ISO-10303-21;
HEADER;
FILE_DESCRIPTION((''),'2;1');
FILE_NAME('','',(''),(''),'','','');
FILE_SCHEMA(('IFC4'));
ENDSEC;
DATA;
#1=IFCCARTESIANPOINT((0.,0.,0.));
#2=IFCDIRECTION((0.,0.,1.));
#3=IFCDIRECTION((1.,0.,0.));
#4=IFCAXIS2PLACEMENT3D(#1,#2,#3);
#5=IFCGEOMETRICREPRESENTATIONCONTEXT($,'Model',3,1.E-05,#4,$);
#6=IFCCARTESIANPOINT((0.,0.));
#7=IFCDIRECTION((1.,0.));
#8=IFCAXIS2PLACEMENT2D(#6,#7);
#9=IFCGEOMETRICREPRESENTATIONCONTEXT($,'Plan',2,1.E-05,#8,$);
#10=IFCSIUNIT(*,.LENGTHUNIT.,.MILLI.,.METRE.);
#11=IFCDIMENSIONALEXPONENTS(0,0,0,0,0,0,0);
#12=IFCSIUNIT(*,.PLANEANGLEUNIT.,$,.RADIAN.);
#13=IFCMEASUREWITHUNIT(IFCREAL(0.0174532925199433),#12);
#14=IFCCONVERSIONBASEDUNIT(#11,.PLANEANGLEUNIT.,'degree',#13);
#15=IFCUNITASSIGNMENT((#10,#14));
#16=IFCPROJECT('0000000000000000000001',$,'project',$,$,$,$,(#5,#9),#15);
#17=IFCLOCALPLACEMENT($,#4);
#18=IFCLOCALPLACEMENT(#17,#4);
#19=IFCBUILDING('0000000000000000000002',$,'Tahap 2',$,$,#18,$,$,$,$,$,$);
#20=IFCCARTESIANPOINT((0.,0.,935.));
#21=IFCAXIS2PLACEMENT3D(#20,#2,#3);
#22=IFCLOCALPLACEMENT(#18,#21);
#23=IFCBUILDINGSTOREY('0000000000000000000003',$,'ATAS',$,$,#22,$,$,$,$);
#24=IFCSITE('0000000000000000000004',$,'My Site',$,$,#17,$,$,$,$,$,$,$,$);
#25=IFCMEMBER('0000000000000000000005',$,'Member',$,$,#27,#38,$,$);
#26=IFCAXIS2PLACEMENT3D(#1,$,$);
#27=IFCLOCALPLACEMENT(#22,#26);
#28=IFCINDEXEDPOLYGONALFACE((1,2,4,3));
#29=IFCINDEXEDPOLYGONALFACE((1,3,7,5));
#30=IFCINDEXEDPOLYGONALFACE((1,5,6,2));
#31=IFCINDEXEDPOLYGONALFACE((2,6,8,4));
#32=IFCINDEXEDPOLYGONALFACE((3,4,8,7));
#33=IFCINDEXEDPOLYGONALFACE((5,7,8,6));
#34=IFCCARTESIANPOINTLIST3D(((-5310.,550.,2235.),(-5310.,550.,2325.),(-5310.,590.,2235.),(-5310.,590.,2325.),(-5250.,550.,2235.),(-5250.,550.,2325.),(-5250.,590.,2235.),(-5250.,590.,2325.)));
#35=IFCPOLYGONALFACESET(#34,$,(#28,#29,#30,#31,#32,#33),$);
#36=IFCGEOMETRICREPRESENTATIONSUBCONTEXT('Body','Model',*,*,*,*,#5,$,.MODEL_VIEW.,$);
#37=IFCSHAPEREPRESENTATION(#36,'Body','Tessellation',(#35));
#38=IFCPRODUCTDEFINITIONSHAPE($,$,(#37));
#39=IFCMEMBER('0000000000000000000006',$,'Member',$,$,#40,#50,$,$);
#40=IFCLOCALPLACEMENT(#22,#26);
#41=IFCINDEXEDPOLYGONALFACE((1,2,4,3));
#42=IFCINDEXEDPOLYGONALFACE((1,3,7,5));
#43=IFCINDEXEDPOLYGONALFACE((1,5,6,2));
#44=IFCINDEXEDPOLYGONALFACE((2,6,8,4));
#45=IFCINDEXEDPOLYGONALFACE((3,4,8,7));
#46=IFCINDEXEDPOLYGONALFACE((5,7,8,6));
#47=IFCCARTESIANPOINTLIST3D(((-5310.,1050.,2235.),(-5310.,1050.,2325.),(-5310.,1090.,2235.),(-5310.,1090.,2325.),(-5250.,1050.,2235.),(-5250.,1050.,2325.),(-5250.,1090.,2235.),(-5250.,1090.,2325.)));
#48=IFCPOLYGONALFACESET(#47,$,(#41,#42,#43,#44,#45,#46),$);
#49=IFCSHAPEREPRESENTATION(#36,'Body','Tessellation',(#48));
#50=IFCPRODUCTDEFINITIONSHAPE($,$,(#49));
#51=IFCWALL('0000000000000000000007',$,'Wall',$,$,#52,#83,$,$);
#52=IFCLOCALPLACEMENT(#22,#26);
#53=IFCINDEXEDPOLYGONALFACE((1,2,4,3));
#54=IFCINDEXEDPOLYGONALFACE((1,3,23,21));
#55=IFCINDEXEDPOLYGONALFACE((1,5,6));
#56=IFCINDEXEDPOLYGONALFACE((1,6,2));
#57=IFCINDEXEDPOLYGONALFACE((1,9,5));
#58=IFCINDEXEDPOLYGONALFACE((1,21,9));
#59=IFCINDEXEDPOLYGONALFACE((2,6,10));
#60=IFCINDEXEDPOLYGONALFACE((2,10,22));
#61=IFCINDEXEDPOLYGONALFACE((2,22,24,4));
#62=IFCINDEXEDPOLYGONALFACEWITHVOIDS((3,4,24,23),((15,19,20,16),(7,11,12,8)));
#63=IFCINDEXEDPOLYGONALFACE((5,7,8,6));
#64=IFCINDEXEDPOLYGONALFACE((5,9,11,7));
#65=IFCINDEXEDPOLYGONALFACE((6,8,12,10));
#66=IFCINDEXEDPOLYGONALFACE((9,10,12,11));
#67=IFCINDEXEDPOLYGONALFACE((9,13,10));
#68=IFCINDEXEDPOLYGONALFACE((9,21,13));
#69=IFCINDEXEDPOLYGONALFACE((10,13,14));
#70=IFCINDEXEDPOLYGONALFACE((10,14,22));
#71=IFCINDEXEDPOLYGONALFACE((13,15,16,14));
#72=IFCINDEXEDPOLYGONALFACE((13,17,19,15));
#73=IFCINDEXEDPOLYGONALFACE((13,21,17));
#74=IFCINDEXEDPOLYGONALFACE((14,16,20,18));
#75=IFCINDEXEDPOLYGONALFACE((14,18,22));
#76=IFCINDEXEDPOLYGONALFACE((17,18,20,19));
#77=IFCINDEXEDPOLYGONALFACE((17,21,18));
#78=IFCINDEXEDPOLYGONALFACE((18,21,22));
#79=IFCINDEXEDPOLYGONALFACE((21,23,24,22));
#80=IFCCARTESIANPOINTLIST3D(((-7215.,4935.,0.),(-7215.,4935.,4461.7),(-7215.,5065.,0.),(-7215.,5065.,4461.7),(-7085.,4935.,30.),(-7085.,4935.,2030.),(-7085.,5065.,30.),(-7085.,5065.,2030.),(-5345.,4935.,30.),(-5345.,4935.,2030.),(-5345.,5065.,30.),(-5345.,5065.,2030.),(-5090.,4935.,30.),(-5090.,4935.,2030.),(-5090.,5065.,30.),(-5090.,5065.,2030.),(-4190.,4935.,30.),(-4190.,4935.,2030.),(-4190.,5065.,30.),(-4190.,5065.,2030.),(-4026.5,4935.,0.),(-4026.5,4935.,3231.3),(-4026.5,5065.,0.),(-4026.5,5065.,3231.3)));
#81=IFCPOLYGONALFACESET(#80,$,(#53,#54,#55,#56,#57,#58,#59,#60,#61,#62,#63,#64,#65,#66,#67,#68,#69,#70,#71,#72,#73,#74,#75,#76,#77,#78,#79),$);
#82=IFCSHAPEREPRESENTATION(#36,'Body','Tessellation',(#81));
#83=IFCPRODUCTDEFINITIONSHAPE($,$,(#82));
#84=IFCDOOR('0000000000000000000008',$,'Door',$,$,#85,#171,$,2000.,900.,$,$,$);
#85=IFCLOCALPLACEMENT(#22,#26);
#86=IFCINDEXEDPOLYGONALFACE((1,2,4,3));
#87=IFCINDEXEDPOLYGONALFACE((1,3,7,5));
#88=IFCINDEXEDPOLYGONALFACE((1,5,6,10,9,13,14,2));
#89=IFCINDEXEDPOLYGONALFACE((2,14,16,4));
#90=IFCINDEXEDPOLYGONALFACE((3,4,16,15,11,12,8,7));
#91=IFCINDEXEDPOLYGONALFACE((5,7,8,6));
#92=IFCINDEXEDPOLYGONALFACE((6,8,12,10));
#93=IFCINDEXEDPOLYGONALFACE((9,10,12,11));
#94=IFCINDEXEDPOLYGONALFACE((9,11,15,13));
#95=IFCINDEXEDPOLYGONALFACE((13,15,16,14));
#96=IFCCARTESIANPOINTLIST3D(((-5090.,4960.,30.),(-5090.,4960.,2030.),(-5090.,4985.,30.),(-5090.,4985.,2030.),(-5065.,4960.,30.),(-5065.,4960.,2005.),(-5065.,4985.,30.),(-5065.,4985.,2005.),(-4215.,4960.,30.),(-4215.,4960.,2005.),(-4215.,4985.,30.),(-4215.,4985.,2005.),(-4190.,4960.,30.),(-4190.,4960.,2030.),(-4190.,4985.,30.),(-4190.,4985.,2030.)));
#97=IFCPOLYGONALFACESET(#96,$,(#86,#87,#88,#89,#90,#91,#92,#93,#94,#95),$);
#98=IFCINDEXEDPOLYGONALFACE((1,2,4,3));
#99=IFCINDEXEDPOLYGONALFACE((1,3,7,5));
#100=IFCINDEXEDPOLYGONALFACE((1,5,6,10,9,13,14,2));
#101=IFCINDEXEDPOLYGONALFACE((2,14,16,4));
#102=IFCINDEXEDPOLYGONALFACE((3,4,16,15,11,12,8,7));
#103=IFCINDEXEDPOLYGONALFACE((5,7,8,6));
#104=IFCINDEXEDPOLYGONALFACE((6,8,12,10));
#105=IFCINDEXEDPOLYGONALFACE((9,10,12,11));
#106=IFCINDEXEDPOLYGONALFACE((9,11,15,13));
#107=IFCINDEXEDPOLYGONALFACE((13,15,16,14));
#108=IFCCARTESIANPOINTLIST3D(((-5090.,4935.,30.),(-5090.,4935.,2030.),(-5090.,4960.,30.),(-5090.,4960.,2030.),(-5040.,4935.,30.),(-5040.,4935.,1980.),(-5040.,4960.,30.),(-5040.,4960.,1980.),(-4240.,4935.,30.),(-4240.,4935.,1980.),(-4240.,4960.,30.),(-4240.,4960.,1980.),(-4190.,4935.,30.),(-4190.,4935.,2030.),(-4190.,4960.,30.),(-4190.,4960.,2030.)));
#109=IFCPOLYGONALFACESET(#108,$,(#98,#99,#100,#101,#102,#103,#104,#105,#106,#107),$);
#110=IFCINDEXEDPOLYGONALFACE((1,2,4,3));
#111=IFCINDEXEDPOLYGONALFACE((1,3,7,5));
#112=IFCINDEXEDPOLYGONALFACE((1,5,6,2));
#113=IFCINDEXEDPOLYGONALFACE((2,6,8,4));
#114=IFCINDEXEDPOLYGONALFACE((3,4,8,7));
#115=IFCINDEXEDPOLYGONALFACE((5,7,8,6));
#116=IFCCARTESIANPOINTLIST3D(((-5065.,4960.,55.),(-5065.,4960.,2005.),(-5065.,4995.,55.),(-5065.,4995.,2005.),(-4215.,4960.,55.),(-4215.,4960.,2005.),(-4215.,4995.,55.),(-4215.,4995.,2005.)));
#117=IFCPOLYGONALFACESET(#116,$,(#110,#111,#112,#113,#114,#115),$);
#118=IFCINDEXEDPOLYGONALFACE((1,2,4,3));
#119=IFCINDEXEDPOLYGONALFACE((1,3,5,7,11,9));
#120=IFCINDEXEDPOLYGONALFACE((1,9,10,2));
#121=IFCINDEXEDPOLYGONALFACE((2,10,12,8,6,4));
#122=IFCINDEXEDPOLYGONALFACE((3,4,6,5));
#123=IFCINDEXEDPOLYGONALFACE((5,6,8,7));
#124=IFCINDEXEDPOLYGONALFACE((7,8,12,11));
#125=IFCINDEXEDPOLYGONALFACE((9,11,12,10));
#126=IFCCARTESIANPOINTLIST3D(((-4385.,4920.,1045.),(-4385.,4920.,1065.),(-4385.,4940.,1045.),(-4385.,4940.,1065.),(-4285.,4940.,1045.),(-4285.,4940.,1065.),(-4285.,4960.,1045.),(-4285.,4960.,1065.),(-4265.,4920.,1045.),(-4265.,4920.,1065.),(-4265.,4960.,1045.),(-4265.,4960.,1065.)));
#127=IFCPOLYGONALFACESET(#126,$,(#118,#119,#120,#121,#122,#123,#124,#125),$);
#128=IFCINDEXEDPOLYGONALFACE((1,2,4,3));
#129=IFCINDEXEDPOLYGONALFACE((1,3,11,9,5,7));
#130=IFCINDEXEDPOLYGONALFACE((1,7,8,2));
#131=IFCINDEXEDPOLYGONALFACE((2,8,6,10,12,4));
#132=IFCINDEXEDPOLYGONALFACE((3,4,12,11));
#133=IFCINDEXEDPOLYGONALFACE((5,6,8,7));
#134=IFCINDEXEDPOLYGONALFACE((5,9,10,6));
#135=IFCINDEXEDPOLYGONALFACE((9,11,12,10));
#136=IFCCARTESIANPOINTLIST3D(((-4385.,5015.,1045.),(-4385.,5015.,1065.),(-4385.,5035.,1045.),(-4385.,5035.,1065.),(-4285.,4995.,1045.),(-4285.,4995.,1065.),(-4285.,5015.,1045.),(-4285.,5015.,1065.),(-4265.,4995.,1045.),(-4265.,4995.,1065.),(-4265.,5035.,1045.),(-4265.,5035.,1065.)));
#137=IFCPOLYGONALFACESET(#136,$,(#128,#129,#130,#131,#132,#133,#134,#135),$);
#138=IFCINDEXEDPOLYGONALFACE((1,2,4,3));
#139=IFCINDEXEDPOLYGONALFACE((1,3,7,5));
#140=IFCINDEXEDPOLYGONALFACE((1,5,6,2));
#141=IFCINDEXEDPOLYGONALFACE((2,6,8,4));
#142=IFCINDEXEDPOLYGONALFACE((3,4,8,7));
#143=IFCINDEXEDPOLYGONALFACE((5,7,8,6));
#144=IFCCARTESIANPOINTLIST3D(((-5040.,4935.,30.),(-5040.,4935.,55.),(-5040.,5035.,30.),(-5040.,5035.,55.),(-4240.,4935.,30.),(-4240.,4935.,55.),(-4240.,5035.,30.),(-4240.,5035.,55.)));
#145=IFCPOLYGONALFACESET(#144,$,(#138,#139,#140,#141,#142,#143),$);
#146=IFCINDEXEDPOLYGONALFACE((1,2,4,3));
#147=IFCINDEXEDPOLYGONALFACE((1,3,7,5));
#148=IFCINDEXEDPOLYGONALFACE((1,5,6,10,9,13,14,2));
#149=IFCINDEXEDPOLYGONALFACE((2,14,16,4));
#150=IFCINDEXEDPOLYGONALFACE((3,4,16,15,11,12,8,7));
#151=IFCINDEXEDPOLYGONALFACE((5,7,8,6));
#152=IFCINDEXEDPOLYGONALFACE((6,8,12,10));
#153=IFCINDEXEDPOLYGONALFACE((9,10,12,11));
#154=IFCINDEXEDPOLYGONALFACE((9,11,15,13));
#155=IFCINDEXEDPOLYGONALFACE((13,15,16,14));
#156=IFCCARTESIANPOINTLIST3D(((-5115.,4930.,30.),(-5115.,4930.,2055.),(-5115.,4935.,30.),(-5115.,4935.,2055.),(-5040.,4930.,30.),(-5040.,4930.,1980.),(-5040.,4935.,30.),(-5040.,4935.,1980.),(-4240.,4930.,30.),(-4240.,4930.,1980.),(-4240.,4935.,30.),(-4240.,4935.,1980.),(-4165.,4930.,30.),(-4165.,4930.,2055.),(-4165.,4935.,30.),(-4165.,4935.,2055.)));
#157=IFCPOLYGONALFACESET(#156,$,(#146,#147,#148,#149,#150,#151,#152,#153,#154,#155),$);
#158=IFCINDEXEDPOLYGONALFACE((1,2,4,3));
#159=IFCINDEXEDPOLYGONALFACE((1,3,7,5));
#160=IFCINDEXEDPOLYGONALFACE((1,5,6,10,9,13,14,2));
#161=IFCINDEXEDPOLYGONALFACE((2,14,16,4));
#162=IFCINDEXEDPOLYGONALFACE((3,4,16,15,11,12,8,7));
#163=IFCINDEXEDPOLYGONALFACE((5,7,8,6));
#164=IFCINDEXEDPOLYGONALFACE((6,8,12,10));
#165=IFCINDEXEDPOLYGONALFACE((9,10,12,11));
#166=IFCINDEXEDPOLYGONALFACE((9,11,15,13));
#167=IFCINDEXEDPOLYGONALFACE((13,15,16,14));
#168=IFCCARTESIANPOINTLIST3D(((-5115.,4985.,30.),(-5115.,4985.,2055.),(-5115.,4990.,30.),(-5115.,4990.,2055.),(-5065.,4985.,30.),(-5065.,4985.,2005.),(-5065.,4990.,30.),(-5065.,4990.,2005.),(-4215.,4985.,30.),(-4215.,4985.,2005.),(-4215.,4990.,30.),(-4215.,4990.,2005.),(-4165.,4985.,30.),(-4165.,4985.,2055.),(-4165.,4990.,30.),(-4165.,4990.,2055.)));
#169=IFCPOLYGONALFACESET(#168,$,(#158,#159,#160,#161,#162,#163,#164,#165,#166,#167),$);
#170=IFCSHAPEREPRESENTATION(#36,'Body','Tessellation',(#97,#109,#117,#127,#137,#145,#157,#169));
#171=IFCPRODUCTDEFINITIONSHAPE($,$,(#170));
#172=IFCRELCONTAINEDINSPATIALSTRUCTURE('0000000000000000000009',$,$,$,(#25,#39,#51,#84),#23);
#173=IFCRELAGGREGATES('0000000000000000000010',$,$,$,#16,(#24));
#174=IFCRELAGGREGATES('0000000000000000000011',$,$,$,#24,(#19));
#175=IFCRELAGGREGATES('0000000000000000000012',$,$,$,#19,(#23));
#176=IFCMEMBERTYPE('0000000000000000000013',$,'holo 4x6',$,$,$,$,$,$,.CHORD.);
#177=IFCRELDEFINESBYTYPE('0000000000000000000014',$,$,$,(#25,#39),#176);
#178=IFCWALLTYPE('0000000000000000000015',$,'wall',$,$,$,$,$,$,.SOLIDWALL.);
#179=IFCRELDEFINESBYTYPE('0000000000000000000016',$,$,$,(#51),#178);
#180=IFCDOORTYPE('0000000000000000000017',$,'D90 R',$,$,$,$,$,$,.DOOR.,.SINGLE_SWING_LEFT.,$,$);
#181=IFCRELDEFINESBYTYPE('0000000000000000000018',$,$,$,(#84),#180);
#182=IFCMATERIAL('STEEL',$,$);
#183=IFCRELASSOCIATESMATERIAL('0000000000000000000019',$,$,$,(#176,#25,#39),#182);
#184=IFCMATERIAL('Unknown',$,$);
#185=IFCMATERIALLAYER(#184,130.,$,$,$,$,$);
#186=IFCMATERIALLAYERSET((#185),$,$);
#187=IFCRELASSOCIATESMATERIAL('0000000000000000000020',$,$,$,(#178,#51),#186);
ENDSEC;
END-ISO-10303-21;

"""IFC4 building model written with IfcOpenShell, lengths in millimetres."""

from ifc_helpers import new_model, entity, si_unit, converted_unit, frame, origin_with_axes, origin_2d_with_axis, place, context, subcontext, project, spatial, line, indexed_curve, rectangle, outline, extrude, clip, halfspace, shape, source, transform, mapped, material, layer, layer_set, layer_usage, material_profile, profile_set, profile_usage, type_object, type_shapes, element, fill, save


model = new_model("IFC4")

# Units and contexts
model_context = context("Model", 3, precision=1e-05, world=origin_with_axes())
plan_context = context("Plan", 2, precision=1e-05, world=origin_2d_with_axis())
body_context_1 = subcontext(model_context, "Body", "Model", "MODEL_VIEW")
body_context_2 = subcontext(plan_context, "Body", "Plan", "PLAN_VIEW")
ifc_project = project(units=[si_unit("LENGTHUNIT", "METRE", prefix="MILLI"), converted_unit("PLANEANGLEUNIT", "degree", entity("IfcReal", 0.0174532925199433), si_unit("PLANEANGLEUNIT", "RADIAN"), dimensions=[0, 0, 0, 0, 0, 0, 0])], contexts=[model_context, plan_context])

# Site, building, storey
site_placement = place(None, origin_with_axes())
site = spatial("IfcSite", under=ifc_project, at=site_placement, Name="My Site")
building_placement = place(site_placement, origin_with_axes())
building = spatial("IfcBuilding", under=site, at=building_placement, Name="Tahap 2")
storey_placement = place(building_placement, frame((0.0, 0.0, 935.0), z_axis=(0.0, 0.0, 1.0), x_axis=(1.0, 0.0, 0.0)))
storey = spatial("IfcBuildingStorey", under=building, at=storey_placement, Name="ATAS")

# Members
ifc_material_1 = material(Name="STEEL")
ifc_material_profile = material_profile(ifc_material_1, rectangle(XDim=40.0, YDim=60.0, kind="CURVE"))
ifc_profile_set = profile_set([ifc_material_profile])
ifc_profile_usage_1 = profile_usage(ifc_profile_set, cardinal=8)
member_type = type_object("IfcMemberType", Name="holo 4x6", PredefinedType="CHORD", material=ifc_profile_set)
member_1_placement = place(storey_placement, frame((-5250.0, 570.0, 2235.0), z_axis=(0.0, 0.0, 1.0), x_axis=(0.0, -1.0, 0.0)))
element("IfcMember", 1, at=member_1_placement, inside=storey, type_object=member_type, material=ifc_profile_usage_1, Name="Member", context=body_context_1, shape_type="SweptSolid", body=[
    extrude(rectangle(XDim=40.0, YDim=60.0, kind="CURVE"), frame((0.0, -30.0, 0.0), z_axis=(0.0, 0.0, 1.0), x_axis=(1.0, 0.0, 0.0)), (0.0, 0.0, 1.0), 90.0),
])
ifc_profile_usage_2 = profile_usage(ifc_profile_set, cardinal=8)
member_2_placement = place(storey_placement, frame((-5250.0, 1070.0, 2235.0), z_axis=(0.0, 0.0, 1.0), x_axis=(0.0, -1.0, 0.0)))
element("IfcMember", 2, at=member_2_placement, inside=storey, type_object=member_type, material=ifc_profile_usage_2, Name="Member", context=body_context_1, shape_type="SweptSolid", body=[
    extrude(rectangle(XDim=40.0, YDim=60.0, kind="CURVE"), frame((0.0, -30.0, 0.0), z_axis=(0.0, 0.0, 1.0), x_axis=(1.0, 0.0, 0.0)), (0.0, 0.0, 1.0), 90.0),
])

# Wall, openings, door
ifc_material_2 = material(Name="Unknown")
ifc_layer_1 = layer(ifc_material_2, 130.0)
ifc_layer_set_1 = layer_set([ifc_layer_1])
ifc_layer_usage_1 = layer_usage(ifc_layer_set_1, "AXIS2", "POSITIVE", 0.0)
wall_type_1 = type_object("IfcWallType", Name="wall", PredefinedType="SOLIDWALL", material=ifc_layer_set_1)
wall_1_placement = place(storey_placement, frame((-7046.5, 4935.0, 0.0), z_axis=(0.0, 0.0, 1.0), x_axis=(1.0, 0.0, 0.0)))
wall_1 = element("IfcWall", 3, at=wall_1_placement, inside=storey, type_object=wall_type_1, material=ifc_layer_usage_1, Name="Wall", context=body_context_1, shape_type="Clipping", body=[
    clip(extrude(outline(indexed_curve([(-168.5, 0.0), (-168.5, 130.0), (3020.0, 130.0), (3020.0, 0.0)], segments=[line(1, 2, 3, 4, 1)])), origin_with_axes(), (0.0, 0.0, 1.0), 5000.0), halfspace(frame((2553.5, 500.0, 3411.3), z_axis=(0.359997, 0.0, 0.932954), x_axis=(-0.932954, 0.0, 0.359997)), False)),
])
shared_shape_1 = source(origin_with_axes(), body_context_1, "Body", "SweptSolid", [
    extrude(outline(indexed_curve([(0.0, 0.0), (900.0, 0.0), (900.0, 2000.0), (0.0, 2000.0)], segments=[line(1, 2, 3, 4, 1)])), frame((0.0, -600.0, 0.0), z_axis=(0.0, -1.0, 0.0), x_axis=(1.0, 0.0, 0.0)), (0.0, 0.0, -1.0), 1200.0),
])
opening_1_placement = place(wall_1_placement, frame((1956.5, 0.0, 30.0), z_axis=(0.0, 0.0, 1.0), x_axis=(1.0, 0.0, 0.0)))
opening_1 = element("IfcOpeningElement", 4, at=opening_1_placement, cuts=wall_1, PredefinedType="OPENING", context=body_context_1, shape_type="MappedRepresentation", body=[
    mapped(shared_shape_1, transform((0.0, 0.0, 0.0), x_axis=(1.0, 0.0, 0.0), y_axis=(0.0, 1.0, 0.0), z_axis=(0.0, 0.0, 1.0), scale=1.0)),
])
opening_2_placement = place(wall_1_placement, frame((1230.8, 0.0, 0.0), z_axis=(0.0, 0.0, 1.0), x_axis=(1.0, 0.0, 0.0)))
element("IfcOpeningElement", 5, at=opening_2_placement, cuts=wall_1, PredefinedType="OPENING", context=body_context_1, shape_type="SweptSolid", body=[
    extrude(outline(indexed_curve([(-1269.4, 0.0), (470.6, 0.0), (470.6, 500.0), (-1269.4, 500.0), (-1269.4, 0.0)])), frame((0.0, 0.0, 30.0), z_axis=(0.0, 0.0, 1.0), x_axis=(1.0, 0.0, 0.0)), (0.0, 0.0, 1.0), 2000.0),
])
door_type = type_object("IfcDoorType", Name="D90 R", OperationType="SINGLE_SWING_LEFT", PredefinedType="DOOR")
shared_shape_2 = source(origin_with_axes(), body_context_1, "Body", "SweptSolid", [
    extrude(outline(indexed_curve([(0.0, 0.0), (0.0, 2000.0), (900.0, 2000.0), (900.0, 0.0), (875.0, 0.0), (875.0, 1975.0), (25.0, 1975.0), (25.0, 0.0)], segments=[line(1, 2, 3, 4, 5, 6, 7, 8, 1)])), frame((0.0, 25.0, 0.0), z_axis=(0.0, -1.0, 0.0), x_axis=(1.0, 0.0, 0.0)), (0.0, 0.0, -1.0), 25.0),
    extrude(outline(indexed_curve([(0.0, 0.0), (0.0, 2000.0), (900.0, 2000.0), (900.0, 0.0), (850.0, 0.0), (850.0, 1950.0), (50.0, 1950.0), (50.0, 0.0)], segments=[line(1, 2, 3, 4, 5, 6, 7, 8, 1)])), frame((0.0, 0.0, 0.0), z_axis=(0.0, -1.0, 0.0), x_axis=(1.0, 0.0, 0.0)), (0.0, 0.0, -1.0), 25.0),
    extrude(outline(indexed_curve([(0.0, 0.0), (850.0, 0.0), (850.0, 35.0), (0.0, 35.0)], segments=[line(1, 2, 3, 4, 1)])), frame((25.0, 25.0, 25.0), z_axis=(0.0, 0.0, 1.0), x_axis=(1.0, 0.0, 0.0)), (0.0, 0.0, 1.0), 1950.0),
    extrude(outline(indexed_curve([(0.0, 0.0), (0.0, -40.0), (-120.0, -40.0), (-120.0, -20.0), (-20.0, -20.0), (-20.0, 0.0)], segments=[line(1, 2, 3, 4, 5, 6, 1)])), frame((825.0, 25.0, 1015.0), z_axis=(0.0, 0.0, 1.0), x_axis=(1.0, 0.0, 0.0)), (0.0, 0.0, 1.0), 20.0),
    extrude(outline(indexed_curve([(0.0, 0.0), (0.0, 40.0), (-120.0, 40.0), (-120.0, 20.0), (-20.0, 20.0), (-20.0, 0.0)], segments=[line(1, 2, 3, 4, 5, 6, 1)])), frame((825.0, 60.0, 1015.0), z_axis=(0.0, 0.0, 1.0), x_axis=(1.0, 0.0, 0.0)), (0.0, 0.0, 1.0), 20.0),
    extrude(outline(indexed_curve([(0.0, 0.0), (800.0, 0.0), (800.0, 100.0), (0.0, 100.0)], segments=[line(1, 2, 3, 4, 1)])), frame((50.0, 0.0, 0.0), z_axis=(0.0, 0.0, 1.0), x_axis=(1.0, 0.0, 0.0)), (0.0, 0.0, 1.0), 25.0),
    extrude(outline(indexed_curve([(0.0, 0.0), (0.0, 2025.0), (950.0, 2025.0), (950.0, 0.0), (875.0, 0.0), (875.0, 1950.0), (75.0, 1950.0), (75.0, 0.0)], segments=[line(1, 2, 3, 4, 5, 6, 7, 8, 1)])), frame((-25.0, -5.0, 0.0), z_axis=(0.0, -1.0, 0.0), x_axis=(1.0, 0.0, 0.0)), (0.0, 0.0, -1.0), 5.0),
    extrude(outline(indexed_curve([(0.0, 0.0), (0.0, 2025.0), (950.0, 2025.0), (950.0, 0.0), (900.0, 0.0), (900.0, 1975.0), (50.0, 1975.0), (50.0, 0.0)], segments=[line(1, 2, 3, 4, 5, 6, 7, 8, 1)])), frame((-25.0, 50.0, 0.0), z_axis=(0.0, -1.0, 0.0), x_axis=(1.0, 0.0, 0.0)), (0.0, 0.0, -1.0), 5.0),
])
shared_shape_3 = source(origin_with_axes(), body_context_2, "Body", "Curve2D", [
    entity("IfcIndexedPolyCurve", entity("IfcCartesianPointList2D", [[0.0, 0.0], [0.0, 50.0], [25.0, 50.0], [25.0, 25.0], [50.0, 25.0], [50.0, 0.0]]), [entity("IfcLineIndex", [1, 2, 3, 4, 5, 6, 1])]),
    entity("IfcIndexedPolyCurve", entity("IfcCartesianPointList2D", [[900.0, 0.0], [900.0, 50.0], [875.0, 50.0], [875.0, 25.0], [850.0, 25.0], [850.0, 0.0]]), [entity("IfcLineIndex", [1, 2, 3, 4, 5, 6, 1])]),
    entity("IfcTrimmedCurve", entity("IfcEllipse", entity("IfcAxis2Placement2D", entity("IfcCartesianPoint", [60.0, 50.0]), entity("IfcDirection", [1.0, 0.0])), 815.0, 850.0), [entity("IfcCartesianPoint", [875.0, 50.0])], [entity("IfcCartesianPoint", [60.0, 900.0])], True, "CARTESIAN"),
    entity("IfcIndexedPolyCurve", entity("IfcCartesianPointList2D", [[25.0, 50.0], [60.0, 50.0], [60.0, 900.0], [25.0, 900.0]]), [entity("IfcLineIndex", [1, 2, 3, 4, 1])]),
])
type_shapes(door_type, [shared_shape_2, shared_shape_3])
door_placement = place(opening_1_placement, frame((0.0, 0.0, 0.0), z_axis=(0.0, 0.0, 1.0), x_axis=(1.0, 0.0, 0.0)))
door = element("IfcDoor", 6, at=door_placement, inside=storey, type_object=door_type, Name="Door", OverallHeight=2000.0, OverallWidth=900.0, shapes=[
    shape(body_context_1, "Body", "MappedRepresentation", [mapped(shared_shape_2, transform((0.0, 0.0, 0.0), x_axis=(1.0, 0.0, 0.0), y_axis=(0.0, 1.0, 0.0), z_axis=(0.0, 0.0, 1.0), scale=1.0))]),
    shape(body_context_2, "Body", "MappedRepresentation", [mapped(shared_shape_3, transform((0.0, 0.0, 0.0), x_axis=(1.0, 0.0, 0.0), y_axis=(0.0, 1.0, 0.0), z_axis=(0.0, 0.0, 1.0), scale=1.0))]),
])
fill(opening_1, door)

save(model, "model.ifc")
